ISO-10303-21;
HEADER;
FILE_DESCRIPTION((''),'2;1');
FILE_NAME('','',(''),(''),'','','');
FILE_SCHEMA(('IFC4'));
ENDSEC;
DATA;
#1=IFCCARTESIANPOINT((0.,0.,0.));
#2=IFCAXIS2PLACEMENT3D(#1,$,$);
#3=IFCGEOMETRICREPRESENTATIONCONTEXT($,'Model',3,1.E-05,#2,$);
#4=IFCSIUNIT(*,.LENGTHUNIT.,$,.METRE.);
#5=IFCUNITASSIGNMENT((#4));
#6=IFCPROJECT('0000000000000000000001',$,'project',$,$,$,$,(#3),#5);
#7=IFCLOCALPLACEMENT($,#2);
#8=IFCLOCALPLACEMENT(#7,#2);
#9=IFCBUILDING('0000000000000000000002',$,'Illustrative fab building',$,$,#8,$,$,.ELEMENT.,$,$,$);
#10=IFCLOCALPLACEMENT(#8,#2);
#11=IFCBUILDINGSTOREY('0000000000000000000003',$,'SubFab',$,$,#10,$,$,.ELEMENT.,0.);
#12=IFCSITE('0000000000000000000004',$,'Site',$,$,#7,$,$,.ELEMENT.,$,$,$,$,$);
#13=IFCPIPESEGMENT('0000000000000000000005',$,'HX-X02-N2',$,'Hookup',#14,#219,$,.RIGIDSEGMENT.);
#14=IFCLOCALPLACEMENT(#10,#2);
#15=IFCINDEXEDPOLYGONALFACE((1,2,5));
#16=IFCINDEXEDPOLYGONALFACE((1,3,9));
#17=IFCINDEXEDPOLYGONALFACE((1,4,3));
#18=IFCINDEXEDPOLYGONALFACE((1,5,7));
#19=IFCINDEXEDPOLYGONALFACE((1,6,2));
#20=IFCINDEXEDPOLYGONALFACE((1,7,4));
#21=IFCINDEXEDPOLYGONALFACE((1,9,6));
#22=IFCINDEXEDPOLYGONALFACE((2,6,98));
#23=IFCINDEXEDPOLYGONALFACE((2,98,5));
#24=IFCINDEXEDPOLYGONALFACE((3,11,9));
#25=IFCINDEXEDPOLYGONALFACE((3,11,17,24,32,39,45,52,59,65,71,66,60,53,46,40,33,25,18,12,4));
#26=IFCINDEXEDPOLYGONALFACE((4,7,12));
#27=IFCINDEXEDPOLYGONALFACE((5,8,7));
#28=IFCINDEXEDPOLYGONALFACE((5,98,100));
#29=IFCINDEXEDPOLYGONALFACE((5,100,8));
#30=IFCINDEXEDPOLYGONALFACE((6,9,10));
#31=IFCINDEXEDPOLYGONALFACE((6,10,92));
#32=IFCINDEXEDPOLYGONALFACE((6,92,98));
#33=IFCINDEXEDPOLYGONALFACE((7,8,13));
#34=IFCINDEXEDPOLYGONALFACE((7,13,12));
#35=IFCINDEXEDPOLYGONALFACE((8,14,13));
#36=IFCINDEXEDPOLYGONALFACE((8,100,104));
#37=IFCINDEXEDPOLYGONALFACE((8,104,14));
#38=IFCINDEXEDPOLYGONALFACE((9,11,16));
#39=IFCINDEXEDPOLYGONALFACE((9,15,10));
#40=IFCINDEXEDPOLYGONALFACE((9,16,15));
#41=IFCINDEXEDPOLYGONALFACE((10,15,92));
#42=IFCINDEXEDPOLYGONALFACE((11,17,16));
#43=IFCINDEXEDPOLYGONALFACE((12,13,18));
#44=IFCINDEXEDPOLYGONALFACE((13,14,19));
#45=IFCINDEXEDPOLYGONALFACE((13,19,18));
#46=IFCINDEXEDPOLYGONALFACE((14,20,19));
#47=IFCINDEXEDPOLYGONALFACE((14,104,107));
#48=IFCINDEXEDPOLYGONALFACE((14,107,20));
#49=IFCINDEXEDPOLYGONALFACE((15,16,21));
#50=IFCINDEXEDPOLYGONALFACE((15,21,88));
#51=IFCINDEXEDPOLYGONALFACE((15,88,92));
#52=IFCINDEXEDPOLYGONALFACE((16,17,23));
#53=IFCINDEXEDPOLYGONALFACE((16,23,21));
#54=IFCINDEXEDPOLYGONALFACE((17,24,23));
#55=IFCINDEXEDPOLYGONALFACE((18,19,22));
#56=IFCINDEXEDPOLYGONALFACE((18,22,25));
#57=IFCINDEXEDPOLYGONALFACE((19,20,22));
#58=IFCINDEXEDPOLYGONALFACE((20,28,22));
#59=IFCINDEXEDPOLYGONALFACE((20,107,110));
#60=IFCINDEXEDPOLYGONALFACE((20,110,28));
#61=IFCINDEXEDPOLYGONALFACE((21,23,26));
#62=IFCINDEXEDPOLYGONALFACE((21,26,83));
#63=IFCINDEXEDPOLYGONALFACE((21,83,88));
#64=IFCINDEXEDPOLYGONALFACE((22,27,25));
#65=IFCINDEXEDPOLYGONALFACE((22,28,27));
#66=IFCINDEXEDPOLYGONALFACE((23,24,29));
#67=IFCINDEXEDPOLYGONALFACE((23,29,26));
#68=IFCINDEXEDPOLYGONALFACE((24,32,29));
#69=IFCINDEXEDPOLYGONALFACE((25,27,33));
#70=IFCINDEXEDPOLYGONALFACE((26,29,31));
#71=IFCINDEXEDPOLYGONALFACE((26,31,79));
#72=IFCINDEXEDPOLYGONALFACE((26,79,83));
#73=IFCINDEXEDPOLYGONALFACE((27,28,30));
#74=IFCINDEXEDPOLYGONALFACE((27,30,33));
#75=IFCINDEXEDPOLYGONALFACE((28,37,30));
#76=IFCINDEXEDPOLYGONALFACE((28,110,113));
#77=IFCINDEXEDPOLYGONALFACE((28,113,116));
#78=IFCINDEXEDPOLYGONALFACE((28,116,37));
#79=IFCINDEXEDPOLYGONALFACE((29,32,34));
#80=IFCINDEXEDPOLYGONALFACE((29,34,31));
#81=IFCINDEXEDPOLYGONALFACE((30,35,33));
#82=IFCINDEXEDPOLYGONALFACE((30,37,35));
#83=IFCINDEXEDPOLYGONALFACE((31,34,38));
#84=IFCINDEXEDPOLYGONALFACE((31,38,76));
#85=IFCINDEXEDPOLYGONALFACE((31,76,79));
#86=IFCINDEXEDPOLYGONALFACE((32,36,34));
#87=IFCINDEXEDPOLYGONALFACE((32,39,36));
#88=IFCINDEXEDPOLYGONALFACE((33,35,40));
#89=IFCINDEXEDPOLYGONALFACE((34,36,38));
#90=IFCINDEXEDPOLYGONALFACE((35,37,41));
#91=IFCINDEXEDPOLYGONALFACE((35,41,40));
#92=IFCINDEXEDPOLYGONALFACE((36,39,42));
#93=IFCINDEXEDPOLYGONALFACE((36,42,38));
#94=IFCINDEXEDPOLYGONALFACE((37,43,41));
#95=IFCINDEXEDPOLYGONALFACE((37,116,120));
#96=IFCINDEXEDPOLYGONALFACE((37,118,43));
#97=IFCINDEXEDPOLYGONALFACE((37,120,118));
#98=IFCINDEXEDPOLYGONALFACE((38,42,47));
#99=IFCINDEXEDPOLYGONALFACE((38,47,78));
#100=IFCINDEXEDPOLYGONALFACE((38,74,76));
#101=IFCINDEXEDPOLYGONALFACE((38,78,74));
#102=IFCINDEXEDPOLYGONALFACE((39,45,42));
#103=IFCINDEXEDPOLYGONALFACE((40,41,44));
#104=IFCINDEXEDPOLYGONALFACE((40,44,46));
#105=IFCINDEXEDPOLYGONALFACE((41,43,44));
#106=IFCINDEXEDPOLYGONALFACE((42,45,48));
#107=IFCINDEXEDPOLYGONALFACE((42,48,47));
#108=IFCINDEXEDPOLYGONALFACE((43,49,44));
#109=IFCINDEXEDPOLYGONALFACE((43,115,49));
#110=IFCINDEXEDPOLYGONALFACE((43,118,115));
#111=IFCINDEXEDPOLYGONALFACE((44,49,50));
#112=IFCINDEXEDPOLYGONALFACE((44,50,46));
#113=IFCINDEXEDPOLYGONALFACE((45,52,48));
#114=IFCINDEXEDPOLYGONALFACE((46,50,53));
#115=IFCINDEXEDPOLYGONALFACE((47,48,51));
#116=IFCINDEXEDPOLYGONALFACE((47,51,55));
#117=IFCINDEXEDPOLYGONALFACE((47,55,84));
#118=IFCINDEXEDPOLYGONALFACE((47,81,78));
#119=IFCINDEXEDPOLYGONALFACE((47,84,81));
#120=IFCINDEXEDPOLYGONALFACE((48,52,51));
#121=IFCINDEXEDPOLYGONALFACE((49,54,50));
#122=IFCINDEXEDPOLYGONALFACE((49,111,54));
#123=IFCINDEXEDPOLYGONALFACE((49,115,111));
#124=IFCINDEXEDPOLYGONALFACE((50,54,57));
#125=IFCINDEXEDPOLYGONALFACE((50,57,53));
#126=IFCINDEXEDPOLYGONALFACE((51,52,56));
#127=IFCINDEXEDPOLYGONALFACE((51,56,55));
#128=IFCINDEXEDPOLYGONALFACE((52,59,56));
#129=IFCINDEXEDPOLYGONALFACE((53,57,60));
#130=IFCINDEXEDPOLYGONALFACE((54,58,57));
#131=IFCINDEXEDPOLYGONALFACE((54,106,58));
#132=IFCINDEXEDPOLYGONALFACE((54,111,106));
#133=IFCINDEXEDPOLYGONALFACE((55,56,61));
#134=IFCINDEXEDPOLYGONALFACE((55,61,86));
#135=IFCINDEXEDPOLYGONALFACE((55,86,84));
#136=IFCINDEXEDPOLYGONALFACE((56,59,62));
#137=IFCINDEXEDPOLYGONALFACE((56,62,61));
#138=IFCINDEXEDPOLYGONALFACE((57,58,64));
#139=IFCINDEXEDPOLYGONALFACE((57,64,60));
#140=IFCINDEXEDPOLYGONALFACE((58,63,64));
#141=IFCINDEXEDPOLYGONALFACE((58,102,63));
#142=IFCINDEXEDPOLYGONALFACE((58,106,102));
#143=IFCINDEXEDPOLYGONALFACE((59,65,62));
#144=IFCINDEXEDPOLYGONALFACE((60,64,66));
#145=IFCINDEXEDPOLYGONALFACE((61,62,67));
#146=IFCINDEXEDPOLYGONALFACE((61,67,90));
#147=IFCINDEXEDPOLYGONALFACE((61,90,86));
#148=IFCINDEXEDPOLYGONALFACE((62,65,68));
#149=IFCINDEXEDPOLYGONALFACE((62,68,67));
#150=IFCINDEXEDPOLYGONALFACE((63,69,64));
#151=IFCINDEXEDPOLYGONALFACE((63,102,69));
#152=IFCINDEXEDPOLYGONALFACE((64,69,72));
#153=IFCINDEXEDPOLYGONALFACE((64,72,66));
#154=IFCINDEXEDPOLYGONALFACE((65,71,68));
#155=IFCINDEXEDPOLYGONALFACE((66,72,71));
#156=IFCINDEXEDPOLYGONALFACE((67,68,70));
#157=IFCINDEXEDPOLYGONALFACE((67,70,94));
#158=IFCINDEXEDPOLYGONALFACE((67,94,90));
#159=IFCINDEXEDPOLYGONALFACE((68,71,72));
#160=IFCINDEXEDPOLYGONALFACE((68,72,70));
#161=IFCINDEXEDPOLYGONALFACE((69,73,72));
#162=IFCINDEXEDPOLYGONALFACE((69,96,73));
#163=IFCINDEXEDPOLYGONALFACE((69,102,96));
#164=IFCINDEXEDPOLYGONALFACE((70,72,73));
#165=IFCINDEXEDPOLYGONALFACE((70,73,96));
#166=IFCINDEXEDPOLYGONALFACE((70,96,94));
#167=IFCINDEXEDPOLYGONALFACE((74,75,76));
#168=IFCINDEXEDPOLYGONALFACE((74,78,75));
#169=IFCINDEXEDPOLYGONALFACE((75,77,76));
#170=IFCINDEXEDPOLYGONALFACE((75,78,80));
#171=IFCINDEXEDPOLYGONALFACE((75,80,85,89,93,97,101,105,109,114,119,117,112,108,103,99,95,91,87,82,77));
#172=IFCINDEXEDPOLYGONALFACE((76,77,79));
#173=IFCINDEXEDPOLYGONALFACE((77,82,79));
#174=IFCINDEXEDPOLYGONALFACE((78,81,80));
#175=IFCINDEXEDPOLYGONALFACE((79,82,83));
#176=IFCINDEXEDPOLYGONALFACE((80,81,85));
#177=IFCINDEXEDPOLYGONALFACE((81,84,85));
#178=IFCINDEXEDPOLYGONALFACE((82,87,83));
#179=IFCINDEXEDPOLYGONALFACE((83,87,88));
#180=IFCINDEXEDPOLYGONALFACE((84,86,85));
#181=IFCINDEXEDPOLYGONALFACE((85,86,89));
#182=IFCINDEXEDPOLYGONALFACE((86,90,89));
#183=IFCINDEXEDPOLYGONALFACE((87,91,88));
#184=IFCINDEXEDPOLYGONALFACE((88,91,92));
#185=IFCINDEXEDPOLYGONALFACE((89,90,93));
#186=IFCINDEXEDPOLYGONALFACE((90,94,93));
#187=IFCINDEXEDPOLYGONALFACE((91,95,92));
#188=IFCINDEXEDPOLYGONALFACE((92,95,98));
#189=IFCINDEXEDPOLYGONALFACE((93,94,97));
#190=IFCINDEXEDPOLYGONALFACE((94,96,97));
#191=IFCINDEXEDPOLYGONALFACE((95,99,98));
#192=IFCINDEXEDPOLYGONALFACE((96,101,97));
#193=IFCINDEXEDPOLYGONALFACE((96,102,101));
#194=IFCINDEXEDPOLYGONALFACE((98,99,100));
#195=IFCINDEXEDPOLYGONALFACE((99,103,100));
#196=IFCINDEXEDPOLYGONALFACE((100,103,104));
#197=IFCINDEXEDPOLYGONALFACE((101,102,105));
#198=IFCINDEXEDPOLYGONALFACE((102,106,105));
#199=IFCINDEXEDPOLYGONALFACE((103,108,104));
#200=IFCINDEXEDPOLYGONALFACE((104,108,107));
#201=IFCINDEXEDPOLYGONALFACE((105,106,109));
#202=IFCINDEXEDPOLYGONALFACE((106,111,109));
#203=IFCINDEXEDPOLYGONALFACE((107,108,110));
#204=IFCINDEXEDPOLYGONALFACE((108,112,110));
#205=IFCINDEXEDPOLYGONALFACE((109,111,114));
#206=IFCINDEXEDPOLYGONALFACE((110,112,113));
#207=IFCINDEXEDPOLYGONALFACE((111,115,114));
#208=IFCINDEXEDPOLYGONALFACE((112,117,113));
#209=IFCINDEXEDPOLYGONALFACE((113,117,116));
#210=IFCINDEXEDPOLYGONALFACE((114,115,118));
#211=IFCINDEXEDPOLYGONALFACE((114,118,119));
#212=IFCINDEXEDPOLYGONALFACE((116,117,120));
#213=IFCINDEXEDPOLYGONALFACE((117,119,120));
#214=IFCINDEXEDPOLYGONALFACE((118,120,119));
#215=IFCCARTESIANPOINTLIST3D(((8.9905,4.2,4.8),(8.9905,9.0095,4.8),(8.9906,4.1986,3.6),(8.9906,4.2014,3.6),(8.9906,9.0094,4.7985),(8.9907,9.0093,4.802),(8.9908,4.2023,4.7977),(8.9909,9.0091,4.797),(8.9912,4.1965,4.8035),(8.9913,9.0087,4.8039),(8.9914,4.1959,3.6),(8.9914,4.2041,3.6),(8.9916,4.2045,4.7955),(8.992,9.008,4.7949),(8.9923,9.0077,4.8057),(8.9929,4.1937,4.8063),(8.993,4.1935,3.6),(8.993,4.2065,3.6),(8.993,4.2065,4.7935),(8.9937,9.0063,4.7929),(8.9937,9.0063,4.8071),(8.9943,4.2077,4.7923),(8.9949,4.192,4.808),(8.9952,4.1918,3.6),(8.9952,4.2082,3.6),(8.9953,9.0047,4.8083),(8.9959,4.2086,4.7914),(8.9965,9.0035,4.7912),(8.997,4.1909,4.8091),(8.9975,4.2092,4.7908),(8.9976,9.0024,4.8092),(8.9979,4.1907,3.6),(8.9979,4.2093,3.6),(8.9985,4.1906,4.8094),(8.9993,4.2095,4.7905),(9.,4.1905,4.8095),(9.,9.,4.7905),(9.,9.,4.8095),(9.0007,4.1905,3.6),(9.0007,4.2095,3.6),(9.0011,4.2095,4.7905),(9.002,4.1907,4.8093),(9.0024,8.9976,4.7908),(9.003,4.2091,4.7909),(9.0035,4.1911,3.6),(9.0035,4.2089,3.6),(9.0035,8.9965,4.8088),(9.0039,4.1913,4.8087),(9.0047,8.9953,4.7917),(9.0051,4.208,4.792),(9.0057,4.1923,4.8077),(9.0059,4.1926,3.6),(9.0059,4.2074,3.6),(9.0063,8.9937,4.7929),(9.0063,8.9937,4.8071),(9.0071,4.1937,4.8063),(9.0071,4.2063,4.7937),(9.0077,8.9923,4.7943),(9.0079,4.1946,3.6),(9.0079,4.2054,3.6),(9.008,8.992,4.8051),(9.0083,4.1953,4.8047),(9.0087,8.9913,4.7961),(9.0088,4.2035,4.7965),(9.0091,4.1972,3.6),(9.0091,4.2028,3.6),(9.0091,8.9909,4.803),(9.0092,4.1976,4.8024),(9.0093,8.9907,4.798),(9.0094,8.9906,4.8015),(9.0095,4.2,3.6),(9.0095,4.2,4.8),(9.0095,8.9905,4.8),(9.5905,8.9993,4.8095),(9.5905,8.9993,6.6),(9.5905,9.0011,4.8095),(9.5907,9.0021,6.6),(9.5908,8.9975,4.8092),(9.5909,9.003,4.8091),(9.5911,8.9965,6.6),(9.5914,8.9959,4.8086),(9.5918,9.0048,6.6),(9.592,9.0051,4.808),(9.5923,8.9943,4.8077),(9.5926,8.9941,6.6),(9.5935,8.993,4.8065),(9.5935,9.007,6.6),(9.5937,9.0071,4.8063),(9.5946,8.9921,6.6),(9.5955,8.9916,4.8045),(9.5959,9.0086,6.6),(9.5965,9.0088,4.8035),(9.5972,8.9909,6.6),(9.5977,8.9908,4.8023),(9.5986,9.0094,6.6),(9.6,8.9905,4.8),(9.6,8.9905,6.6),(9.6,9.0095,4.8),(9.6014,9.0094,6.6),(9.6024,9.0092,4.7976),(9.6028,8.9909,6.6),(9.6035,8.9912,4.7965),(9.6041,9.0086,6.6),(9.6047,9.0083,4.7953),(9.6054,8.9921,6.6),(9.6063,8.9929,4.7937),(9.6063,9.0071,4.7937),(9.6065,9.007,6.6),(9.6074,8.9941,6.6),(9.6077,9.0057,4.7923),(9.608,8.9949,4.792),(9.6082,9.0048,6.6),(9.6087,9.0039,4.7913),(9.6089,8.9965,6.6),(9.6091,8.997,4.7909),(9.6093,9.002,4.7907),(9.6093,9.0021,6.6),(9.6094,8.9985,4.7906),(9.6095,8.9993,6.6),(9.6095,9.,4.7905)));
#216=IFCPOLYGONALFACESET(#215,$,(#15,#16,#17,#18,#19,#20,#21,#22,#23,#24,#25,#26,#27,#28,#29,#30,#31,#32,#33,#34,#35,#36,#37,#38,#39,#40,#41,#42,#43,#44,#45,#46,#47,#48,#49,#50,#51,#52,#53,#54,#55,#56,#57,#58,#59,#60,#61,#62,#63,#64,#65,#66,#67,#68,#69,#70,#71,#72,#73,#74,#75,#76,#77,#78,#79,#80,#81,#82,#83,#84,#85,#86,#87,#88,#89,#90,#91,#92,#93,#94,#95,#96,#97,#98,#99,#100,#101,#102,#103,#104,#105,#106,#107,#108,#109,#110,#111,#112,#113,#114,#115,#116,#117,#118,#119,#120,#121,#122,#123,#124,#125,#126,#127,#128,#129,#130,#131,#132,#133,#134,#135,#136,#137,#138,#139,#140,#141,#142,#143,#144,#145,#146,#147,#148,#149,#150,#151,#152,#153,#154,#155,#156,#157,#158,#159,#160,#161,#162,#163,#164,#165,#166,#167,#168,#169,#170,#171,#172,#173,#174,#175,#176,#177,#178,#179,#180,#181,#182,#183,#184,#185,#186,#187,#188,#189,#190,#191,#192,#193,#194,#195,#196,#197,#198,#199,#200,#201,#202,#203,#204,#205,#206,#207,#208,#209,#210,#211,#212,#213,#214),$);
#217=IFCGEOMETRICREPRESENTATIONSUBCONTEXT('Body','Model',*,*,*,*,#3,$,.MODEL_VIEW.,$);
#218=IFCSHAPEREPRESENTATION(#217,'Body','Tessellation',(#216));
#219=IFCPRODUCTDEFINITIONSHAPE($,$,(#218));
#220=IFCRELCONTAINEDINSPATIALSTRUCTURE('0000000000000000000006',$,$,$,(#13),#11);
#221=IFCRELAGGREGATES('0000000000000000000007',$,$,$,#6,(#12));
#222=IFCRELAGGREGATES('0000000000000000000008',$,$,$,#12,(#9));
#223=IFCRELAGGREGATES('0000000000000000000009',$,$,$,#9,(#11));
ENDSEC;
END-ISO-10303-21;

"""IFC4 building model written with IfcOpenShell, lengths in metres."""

from ifc_helpers import new_model, entity, si_unit, origin, place, context, subcontext, project, spatial, element, save


model = new_model("IFC4")

# Units and contexts
model_context = context("Model", 3, precision=1e-05, world=origin())
body_context = subcontext(model_context, "Body", "Model", "MODEL_VIEW")
ifc_project = project(units=[si_unit("LENGTHUNIT", "METRE")], contexts=[model_context])

# Site, building, storey
site_placement = place(None, origin())
site = spatial("IfcSite", under=ifc_project, at=site_placement, Name="Site", CompositionType="ELEMENT")
building_placement = place(site_placement, origin())
building = spatial("IfcBuilding", under=site, at=building_placement, Name="Illustrative fab building", CompositionType="ELEMENT")
storey_placement = place(building_placement, origin())
storey = spatial("IfcBuildingStorey", under=building, at=storey_placement, Name="SubFab", CompositionType="ELEMENT", Elevation=0.0)

# Pipe segment
pipe_segment_1_placement = place(storey_placement, origin())
element("IfcPipeSegment", 1, at=pipe_segment_1_placement, inside=storey, Name="HX-X02-N2", ObjectType="Hookup", PredefinedType="RIGIDSEGMENT", context=body_context, shape_type="AdvancedSweptSolid", body=[
    entity("IfcSweptDiskSolid", entity("IfcPolyline", [entity("IfcCartesianPoint", [9.0, 4.2, 3.6]), entity("IfcCartesianPoint", [9.0, 4.2, 4.8]), entity("IfcCartesianPoint", [9.0, 9.0, 4.8]), entity("IfcCartesianPoint", [9.6, 9.0, 4.8]), entity("IfcCartesianPoint", [9.6, 9.0, 6.6])]), 0.0095),
])

save(model, "model.ifc")
